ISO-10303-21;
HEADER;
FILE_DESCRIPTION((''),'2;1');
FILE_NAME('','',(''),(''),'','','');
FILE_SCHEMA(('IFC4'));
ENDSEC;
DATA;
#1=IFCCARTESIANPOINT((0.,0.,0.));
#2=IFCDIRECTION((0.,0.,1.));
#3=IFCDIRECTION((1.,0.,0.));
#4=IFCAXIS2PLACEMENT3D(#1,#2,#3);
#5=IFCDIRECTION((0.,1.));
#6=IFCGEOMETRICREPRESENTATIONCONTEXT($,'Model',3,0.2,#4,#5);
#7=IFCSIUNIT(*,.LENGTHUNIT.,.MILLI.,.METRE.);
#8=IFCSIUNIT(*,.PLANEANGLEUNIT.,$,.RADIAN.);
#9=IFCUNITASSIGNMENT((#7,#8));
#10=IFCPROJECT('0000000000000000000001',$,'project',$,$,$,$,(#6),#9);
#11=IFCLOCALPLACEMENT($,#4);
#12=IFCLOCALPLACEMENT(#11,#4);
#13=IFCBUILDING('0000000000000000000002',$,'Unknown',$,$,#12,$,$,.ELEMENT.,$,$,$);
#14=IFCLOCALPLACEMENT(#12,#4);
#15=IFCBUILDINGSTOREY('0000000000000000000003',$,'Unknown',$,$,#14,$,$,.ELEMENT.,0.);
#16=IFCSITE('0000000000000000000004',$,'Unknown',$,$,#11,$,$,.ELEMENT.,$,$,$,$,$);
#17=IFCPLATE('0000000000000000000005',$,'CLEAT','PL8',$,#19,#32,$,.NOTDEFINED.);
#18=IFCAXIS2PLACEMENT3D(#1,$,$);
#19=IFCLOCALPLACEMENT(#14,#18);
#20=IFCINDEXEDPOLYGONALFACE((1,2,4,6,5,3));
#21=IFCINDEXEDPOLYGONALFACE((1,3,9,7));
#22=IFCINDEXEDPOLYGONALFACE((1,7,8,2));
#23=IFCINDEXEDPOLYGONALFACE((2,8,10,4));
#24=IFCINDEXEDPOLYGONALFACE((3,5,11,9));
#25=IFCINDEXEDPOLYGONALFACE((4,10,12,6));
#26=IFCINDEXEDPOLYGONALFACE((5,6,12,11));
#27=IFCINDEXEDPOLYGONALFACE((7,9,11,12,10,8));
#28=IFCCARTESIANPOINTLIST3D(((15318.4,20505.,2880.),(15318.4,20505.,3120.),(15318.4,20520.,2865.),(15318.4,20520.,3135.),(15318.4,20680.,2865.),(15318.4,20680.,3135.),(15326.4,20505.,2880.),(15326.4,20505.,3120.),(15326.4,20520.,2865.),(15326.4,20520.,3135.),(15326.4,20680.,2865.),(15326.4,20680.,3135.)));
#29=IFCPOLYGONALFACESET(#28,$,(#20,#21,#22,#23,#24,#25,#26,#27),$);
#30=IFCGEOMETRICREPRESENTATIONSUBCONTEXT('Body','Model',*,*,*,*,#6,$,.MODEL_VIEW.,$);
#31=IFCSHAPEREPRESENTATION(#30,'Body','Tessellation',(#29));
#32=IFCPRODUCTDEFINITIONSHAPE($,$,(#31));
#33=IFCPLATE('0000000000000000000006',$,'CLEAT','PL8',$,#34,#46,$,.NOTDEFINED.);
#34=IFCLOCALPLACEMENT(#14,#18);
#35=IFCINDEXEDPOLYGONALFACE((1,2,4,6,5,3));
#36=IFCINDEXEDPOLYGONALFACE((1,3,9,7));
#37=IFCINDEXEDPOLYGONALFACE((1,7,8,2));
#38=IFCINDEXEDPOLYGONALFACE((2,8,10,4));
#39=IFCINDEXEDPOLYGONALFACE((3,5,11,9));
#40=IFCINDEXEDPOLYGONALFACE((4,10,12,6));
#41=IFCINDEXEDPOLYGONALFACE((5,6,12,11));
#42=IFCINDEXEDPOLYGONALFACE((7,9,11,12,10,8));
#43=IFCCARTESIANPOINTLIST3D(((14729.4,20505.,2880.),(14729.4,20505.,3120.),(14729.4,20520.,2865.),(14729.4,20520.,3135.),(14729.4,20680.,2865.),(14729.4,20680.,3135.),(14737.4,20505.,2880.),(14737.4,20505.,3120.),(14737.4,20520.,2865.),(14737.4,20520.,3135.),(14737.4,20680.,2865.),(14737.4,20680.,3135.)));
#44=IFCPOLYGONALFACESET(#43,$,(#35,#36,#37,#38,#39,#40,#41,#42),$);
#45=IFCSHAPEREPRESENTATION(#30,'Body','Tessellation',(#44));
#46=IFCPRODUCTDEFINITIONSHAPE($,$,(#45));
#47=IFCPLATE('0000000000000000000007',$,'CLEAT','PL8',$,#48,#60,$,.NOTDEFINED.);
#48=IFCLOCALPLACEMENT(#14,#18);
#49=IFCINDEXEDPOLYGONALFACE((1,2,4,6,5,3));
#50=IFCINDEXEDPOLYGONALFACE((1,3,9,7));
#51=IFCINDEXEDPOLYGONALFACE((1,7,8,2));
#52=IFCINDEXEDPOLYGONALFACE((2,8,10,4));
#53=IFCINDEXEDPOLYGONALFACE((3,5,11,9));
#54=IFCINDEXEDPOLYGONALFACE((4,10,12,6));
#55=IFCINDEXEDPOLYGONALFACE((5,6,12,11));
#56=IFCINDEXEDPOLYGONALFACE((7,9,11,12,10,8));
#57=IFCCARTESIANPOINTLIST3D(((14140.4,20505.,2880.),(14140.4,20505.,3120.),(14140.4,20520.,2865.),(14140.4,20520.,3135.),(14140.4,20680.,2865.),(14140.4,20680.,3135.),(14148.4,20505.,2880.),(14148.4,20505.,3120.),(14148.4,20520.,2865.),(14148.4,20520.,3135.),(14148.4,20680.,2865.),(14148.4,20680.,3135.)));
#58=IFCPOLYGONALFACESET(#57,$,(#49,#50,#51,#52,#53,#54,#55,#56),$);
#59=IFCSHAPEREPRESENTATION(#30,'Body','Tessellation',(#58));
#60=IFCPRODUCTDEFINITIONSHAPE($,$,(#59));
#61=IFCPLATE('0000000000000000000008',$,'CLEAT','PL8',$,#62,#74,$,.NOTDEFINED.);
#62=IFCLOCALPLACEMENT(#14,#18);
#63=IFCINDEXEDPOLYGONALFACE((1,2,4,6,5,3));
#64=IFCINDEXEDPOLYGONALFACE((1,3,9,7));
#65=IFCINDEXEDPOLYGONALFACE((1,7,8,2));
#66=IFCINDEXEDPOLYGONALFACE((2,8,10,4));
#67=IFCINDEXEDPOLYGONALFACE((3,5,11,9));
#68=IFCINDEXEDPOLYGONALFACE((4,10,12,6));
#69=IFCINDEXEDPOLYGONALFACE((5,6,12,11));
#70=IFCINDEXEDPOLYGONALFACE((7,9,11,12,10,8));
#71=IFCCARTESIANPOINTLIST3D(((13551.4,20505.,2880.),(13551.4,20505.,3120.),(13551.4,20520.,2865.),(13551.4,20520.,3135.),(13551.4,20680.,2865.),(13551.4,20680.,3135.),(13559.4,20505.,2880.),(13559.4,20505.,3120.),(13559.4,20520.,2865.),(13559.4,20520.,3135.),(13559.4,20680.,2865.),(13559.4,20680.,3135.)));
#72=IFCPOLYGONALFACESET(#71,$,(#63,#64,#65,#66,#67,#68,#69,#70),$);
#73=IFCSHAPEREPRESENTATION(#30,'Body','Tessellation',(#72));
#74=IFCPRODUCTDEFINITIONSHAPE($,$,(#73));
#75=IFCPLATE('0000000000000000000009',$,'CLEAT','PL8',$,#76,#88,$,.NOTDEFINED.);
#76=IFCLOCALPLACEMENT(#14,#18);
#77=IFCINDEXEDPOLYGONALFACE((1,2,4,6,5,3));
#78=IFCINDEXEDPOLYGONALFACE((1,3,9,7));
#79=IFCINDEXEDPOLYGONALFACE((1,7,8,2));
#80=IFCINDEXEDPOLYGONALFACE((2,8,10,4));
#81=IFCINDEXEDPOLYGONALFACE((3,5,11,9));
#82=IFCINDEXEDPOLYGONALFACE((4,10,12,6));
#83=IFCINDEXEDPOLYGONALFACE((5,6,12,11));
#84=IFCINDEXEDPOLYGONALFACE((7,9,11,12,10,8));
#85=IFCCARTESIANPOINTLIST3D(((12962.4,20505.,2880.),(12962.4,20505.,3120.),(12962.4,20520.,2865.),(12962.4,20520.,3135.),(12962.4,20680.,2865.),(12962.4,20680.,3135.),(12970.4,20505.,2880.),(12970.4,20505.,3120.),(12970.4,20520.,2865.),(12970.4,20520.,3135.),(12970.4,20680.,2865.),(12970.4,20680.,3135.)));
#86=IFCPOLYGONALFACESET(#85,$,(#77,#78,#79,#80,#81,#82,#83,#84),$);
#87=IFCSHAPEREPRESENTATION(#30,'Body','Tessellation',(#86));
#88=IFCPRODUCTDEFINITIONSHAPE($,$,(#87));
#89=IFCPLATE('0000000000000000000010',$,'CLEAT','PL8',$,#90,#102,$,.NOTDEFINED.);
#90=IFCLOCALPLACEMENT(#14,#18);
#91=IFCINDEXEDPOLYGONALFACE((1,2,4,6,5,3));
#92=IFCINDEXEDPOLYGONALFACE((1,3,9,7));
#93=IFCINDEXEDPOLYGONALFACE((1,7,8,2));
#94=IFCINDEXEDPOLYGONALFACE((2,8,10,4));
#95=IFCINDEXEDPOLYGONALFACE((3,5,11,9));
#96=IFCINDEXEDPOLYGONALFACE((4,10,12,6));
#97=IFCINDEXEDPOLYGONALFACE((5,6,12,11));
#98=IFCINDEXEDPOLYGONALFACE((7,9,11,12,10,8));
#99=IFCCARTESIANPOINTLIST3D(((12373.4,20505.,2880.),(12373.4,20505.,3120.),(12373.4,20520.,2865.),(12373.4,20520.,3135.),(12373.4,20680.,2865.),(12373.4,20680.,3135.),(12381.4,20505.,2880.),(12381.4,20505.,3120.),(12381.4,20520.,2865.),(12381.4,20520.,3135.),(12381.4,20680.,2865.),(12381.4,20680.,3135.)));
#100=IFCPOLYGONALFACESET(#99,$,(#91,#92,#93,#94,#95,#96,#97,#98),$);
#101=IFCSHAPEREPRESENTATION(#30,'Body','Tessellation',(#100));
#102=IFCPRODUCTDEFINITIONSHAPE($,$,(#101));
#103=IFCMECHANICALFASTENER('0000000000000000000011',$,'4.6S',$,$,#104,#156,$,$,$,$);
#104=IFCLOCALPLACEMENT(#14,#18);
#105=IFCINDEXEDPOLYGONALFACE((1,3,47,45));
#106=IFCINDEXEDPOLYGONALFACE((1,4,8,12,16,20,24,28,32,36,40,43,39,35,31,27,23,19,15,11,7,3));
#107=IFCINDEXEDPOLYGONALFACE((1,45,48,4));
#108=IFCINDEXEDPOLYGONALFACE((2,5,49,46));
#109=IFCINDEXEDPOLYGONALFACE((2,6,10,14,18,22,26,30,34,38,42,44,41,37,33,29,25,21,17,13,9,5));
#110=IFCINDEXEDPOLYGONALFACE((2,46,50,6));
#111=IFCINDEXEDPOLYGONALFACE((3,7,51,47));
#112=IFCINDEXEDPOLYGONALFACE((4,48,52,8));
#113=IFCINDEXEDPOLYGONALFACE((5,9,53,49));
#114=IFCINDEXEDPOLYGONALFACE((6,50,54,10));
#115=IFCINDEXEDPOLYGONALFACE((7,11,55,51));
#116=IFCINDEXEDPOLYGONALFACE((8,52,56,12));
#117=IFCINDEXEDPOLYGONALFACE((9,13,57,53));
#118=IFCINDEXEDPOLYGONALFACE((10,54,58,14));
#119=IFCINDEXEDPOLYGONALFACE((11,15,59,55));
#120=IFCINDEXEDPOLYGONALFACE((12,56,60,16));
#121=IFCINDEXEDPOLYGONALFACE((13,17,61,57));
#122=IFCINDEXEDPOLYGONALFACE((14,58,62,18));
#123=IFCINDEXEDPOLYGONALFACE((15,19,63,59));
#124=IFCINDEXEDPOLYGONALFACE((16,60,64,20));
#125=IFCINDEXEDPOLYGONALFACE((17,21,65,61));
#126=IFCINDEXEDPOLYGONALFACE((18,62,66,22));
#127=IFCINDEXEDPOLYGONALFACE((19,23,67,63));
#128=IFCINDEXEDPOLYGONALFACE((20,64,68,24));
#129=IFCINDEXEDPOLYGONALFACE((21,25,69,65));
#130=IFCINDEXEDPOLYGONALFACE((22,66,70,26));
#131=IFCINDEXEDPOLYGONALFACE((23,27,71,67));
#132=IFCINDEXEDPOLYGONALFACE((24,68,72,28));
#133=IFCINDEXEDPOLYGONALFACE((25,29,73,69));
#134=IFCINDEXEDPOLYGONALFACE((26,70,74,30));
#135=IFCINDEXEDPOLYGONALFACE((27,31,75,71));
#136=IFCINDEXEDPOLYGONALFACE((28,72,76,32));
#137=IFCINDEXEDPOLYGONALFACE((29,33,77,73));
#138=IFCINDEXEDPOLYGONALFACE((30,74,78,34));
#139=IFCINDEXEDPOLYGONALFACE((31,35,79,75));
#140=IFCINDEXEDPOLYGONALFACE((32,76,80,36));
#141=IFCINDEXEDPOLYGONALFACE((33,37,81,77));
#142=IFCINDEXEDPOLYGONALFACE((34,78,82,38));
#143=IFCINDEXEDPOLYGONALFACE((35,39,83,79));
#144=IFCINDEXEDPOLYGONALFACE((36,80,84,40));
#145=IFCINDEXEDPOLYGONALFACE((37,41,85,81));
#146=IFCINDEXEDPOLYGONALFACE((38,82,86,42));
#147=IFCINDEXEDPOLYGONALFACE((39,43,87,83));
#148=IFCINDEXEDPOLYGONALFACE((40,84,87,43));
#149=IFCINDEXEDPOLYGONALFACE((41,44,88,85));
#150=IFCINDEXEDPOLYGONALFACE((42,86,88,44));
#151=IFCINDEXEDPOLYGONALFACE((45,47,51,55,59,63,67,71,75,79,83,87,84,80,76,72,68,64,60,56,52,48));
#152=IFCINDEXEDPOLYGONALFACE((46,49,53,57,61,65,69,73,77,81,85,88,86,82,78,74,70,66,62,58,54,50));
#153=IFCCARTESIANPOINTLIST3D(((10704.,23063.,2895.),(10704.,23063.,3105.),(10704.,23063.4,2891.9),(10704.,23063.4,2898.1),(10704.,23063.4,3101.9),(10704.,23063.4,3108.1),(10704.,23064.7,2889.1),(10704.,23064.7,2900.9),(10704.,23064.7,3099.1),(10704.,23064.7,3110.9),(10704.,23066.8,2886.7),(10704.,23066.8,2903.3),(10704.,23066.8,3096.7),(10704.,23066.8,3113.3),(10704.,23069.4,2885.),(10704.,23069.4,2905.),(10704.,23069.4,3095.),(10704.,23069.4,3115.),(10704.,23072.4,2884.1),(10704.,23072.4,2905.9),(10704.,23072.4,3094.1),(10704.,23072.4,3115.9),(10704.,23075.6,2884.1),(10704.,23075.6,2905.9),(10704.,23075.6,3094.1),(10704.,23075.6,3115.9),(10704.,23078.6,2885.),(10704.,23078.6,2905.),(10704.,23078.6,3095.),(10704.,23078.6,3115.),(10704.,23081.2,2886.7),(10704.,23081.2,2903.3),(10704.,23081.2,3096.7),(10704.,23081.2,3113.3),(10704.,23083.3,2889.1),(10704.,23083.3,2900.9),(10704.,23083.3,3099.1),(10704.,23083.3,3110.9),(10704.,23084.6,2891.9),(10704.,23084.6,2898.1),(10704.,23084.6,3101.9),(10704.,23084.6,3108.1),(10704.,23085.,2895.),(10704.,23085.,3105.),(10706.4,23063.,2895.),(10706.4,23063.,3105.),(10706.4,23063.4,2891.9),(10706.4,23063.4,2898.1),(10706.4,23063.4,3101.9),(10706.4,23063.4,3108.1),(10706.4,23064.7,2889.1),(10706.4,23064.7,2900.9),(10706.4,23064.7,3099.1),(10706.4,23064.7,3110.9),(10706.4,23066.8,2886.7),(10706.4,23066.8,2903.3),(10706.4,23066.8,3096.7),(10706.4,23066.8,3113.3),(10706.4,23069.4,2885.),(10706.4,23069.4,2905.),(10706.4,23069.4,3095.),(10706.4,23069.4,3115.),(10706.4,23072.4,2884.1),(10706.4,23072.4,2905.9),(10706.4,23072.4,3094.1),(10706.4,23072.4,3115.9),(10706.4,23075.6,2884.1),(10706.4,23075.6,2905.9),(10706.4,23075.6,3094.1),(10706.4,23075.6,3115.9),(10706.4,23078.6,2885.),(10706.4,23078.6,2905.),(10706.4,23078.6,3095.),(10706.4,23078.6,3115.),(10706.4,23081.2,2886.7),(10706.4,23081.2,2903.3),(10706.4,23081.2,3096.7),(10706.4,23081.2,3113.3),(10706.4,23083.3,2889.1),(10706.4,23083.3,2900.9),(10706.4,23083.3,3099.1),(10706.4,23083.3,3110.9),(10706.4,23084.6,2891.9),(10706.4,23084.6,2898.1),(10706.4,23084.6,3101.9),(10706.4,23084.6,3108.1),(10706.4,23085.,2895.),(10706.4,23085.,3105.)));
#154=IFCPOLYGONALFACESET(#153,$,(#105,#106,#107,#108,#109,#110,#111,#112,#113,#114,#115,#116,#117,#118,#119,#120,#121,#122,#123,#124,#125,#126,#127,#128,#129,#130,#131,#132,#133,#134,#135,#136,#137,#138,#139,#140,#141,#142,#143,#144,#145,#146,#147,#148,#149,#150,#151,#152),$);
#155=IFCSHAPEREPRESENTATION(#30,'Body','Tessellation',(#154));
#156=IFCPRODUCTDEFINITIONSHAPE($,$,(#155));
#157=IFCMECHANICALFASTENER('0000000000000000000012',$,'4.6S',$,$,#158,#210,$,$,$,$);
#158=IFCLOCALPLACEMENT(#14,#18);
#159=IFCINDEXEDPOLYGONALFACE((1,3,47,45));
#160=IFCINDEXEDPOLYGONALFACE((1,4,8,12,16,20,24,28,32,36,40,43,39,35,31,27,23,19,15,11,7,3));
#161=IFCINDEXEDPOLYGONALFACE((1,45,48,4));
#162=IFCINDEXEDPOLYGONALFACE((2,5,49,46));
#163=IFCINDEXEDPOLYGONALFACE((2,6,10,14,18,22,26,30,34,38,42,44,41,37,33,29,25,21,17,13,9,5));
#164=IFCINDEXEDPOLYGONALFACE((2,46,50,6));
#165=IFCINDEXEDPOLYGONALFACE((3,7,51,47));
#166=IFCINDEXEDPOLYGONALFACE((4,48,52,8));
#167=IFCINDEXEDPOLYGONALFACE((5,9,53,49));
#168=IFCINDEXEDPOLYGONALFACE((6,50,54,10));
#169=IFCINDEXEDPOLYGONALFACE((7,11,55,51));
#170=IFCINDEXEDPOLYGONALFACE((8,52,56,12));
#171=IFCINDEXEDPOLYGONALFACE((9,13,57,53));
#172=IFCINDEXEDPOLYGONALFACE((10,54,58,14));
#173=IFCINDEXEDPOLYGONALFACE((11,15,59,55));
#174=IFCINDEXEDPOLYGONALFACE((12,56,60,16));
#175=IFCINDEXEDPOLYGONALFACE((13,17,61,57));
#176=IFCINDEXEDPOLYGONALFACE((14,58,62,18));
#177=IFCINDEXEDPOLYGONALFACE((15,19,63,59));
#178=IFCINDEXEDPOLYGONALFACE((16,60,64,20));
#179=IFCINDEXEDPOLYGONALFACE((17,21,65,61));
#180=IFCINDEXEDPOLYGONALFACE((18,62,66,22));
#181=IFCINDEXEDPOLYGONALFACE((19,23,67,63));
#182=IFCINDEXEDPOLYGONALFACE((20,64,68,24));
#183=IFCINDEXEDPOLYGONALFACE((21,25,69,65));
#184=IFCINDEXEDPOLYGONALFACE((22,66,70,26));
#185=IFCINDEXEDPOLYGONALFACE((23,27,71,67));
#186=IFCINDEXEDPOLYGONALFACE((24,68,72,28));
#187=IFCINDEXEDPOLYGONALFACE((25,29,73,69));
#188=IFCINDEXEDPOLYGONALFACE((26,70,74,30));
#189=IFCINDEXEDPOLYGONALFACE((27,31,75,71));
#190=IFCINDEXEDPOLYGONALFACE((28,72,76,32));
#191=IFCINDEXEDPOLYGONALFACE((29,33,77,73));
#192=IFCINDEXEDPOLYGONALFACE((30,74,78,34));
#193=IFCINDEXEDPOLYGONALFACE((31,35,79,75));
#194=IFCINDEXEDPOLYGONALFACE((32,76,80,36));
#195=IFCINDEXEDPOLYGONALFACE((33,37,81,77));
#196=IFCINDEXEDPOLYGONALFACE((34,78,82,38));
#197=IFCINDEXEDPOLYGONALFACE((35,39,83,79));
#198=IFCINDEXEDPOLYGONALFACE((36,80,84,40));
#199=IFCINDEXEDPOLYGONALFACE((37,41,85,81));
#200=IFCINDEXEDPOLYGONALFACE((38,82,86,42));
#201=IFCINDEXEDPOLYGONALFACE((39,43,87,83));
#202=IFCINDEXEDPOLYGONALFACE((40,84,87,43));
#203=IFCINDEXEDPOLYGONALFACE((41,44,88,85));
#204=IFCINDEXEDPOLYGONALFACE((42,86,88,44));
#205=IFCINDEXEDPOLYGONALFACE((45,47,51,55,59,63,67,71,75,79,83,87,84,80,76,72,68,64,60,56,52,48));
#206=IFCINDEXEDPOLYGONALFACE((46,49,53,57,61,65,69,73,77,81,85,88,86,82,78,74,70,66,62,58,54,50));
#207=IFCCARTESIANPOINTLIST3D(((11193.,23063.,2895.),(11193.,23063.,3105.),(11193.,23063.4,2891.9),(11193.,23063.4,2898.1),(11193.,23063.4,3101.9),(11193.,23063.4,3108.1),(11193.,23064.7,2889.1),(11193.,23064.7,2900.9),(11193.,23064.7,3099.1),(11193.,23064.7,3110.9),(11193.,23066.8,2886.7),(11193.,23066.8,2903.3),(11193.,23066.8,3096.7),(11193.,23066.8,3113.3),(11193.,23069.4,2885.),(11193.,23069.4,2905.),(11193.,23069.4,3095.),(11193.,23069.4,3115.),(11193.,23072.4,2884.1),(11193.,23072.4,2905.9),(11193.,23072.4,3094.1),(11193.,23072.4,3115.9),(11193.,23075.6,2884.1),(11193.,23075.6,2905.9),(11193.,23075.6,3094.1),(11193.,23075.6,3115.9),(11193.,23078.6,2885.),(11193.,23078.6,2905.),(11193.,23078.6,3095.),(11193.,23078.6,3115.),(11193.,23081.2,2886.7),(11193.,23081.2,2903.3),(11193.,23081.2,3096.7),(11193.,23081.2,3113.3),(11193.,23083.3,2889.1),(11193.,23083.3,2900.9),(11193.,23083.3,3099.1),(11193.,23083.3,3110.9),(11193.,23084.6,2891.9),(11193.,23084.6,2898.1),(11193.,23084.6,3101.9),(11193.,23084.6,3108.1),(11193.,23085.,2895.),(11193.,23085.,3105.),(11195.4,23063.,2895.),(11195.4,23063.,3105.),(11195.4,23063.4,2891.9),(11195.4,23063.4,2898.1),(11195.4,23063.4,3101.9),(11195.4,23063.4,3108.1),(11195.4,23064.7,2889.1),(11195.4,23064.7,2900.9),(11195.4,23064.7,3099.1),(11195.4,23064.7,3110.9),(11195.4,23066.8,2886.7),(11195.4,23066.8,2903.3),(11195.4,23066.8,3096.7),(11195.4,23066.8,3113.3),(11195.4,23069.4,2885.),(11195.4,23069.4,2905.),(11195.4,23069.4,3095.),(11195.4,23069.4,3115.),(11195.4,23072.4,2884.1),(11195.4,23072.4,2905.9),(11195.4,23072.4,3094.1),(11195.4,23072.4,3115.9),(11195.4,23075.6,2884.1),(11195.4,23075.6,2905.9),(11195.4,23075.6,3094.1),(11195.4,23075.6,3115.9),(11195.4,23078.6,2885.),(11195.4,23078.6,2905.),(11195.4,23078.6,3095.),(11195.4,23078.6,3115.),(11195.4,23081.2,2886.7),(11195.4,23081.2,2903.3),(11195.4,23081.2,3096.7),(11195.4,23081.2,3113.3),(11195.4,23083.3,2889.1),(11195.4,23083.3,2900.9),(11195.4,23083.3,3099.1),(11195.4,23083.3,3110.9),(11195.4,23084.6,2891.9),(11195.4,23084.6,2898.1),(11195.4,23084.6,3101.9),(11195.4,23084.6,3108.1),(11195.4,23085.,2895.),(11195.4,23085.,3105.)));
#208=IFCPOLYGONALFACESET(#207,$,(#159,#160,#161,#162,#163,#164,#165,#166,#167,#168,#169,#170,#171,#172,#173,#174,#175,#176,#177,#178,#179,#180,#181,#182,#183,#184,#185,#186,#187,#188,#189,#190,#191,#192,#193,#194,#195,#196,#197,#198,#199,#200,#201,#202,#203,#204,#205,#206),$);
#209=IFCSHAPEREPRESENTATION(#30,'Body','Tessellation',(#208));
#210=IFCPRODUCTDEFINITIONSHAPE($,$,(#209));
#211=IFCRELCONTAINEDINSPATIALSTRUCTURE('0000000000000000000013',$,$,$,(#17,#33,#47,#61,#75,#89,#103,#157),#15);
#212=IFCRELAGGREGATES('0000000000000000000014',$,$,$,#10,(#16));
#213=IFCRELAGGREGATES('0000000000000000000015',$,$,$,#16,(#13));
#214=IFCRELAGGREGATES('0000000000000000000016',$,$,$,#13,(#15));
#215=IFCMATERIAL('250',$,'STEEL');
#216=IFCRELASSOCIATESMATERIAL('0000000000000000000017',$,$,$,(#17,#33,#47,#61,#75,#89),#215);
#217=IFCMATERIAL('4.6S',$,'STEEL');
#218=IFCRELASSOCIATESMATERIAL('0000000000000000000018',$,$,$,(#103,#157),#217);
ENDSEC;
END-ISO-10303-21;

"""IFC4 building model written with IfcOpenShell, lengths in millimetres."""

from ifc_helpers import new_model, si_unit, direction, frame, origin_with_axes, place, context, subcontext, project, spatial, line, arc, indexed_curve, outline, extrude, source, transform, mapped, material, element, save


model = new_model("IFC4")

# Units and contexts
model_context = context("Model", 3, precision=0.2, world=origin_with_axes(), true_north=direction((0.0, 1.0)))
body_context = subcontext(model_context, "Body", "Model", "MODEL_VIEW")
ifc_project = project(units=[si_unit("LENGTHUNIT", "METRE", prefix="MILLI"), si_unit("PLANEANGLEUNIT", "RADIAN")], contexts=[model_context])

# Site, building, storey
site_placement = place(None, origin_with_axes())
site = spatial("IfcSite", under=ifc_project, at=site_placement, Name="Unknown", CompositionType="ELEMENT")
building_placement = place(site_placement, origin_with_axes())
building = spatial("IfcBuilding", under=site, at=building_placement, Name="Unknown", CompositionType="ELEMENT")
storey_placement = place(building_placement, origin_with_axes())
storey = spatial("IfcBuildingStorey", under=building, at=storey_placement, Name="Unknown", CompositionType="ELEMENT", Elevation=0.0)

# Plates
ifc_material_1 = material(Name="250", Category="STEEL")
for number, where, z_axis, x_axis, name in (
    (1, (15322.4, 20505.0, 2865.0), (1.0, 0.0, 0.0), (0.0, 1.0, 0.0), "CLEAT"),
    (2, (14733.4, 20505.0, 2865.0), (1.0, 0.0, 0.0), (0.0, 1.0, 0.0), "CLEAT"),
    (3, (14144.4, 20505.0, 2865.0), (1.0, 0.0, 0.0), (0.0, 1.0, 0.0), "CLEAT"),
    (4, (13555.4, 20505.0, 2865.0), (1.0, 0.0, 0.0), (0.0, 1.0, 0.0), "CLEAT"),
    (5, (12966.4, 20505.0, 2865.0), (1.0, 0.0, 0.0), (0.0, 1.0, 0.0), "CLEAT"),
    (6, (12377.4, 20505.0, 2865.0), (1.0, 0.0, 0.0), (0.0, 1.0, 0.0), "CLEAT"),
):
    element("IfcPlate", number, at=place(storey_placement, frame(where, z_axis=z_axis, x_axis=x_axis)), inside=storey, material=ifc_material_1, Name=name, Description="PL8", PredefinedType="NOTDEFINED", context=body_context, shape_type="SolidModel", body=[
        extrude(outline(indexed_curve([(0.0, 15.0), (15.0, 0.0), (174.9, 0.0), (174.9, 270.0), (15.0, 270.0), (0.0, 255.0)], segments=[line(1, 2, 3, 4, 5, 6, 1)])), frame((0.0, 0.0, 4.0), z_axis=(0.0, 0.0, 1.0), x_axis=(1.0, 0.0, 0.0)), (0.0, 0.0, -1.0), 8.0),
    ])

# Mechanical fasteners
ifc_material_2 = material(Name="4.6S", Category="STEEL")
shared_shape_1 = source(origin_with_axes(), body_context, "Body", "SweptSolid", [
    extrude(outline(indexed_curve([(11.0, 0.0), (0.0, 11.0), (-11.0, 0.0), (0.0, -11.0)], segments=[arc(1, 2, 3), arc(3, 4, 1)])), frame((0.0, 0.0, 1.2), z_axis=(0.0, 0.0, -1.0), x_axis=(0.0, 1.0, 0.0)), (0.0, 0.0, 1.0), 2.4),
])
for number, where, z_axis, x_axis, name in (
    (7, (10705.2, 23074.0, 2895.0), (-1.0, 0.0, 0.0), (0.0, 0.0, 1.0), "4.6S"),
    (8, (11194.2, 23074.0, 2895.0), (-1.0, 0.0, 0.0), (0.0, 0.0, 1.0), "4.6S"),
):
    element("IfcMechanicalFastener", number, at=place(storey_placement, frame(where, z_axis=z_axis, x_axis=x_axis)), inside=storey, material=ifc_material_2, Name=name, context=body_context, shape_type="MappedRepresentation", body=[
        mapped(shared_shape_1, transform((0.0, 0.0, 0.0))),
        mapped(shared_shape_1, transform((210.0, 0.0, 0.0))),
    ])

save(model, "model.ifc")
